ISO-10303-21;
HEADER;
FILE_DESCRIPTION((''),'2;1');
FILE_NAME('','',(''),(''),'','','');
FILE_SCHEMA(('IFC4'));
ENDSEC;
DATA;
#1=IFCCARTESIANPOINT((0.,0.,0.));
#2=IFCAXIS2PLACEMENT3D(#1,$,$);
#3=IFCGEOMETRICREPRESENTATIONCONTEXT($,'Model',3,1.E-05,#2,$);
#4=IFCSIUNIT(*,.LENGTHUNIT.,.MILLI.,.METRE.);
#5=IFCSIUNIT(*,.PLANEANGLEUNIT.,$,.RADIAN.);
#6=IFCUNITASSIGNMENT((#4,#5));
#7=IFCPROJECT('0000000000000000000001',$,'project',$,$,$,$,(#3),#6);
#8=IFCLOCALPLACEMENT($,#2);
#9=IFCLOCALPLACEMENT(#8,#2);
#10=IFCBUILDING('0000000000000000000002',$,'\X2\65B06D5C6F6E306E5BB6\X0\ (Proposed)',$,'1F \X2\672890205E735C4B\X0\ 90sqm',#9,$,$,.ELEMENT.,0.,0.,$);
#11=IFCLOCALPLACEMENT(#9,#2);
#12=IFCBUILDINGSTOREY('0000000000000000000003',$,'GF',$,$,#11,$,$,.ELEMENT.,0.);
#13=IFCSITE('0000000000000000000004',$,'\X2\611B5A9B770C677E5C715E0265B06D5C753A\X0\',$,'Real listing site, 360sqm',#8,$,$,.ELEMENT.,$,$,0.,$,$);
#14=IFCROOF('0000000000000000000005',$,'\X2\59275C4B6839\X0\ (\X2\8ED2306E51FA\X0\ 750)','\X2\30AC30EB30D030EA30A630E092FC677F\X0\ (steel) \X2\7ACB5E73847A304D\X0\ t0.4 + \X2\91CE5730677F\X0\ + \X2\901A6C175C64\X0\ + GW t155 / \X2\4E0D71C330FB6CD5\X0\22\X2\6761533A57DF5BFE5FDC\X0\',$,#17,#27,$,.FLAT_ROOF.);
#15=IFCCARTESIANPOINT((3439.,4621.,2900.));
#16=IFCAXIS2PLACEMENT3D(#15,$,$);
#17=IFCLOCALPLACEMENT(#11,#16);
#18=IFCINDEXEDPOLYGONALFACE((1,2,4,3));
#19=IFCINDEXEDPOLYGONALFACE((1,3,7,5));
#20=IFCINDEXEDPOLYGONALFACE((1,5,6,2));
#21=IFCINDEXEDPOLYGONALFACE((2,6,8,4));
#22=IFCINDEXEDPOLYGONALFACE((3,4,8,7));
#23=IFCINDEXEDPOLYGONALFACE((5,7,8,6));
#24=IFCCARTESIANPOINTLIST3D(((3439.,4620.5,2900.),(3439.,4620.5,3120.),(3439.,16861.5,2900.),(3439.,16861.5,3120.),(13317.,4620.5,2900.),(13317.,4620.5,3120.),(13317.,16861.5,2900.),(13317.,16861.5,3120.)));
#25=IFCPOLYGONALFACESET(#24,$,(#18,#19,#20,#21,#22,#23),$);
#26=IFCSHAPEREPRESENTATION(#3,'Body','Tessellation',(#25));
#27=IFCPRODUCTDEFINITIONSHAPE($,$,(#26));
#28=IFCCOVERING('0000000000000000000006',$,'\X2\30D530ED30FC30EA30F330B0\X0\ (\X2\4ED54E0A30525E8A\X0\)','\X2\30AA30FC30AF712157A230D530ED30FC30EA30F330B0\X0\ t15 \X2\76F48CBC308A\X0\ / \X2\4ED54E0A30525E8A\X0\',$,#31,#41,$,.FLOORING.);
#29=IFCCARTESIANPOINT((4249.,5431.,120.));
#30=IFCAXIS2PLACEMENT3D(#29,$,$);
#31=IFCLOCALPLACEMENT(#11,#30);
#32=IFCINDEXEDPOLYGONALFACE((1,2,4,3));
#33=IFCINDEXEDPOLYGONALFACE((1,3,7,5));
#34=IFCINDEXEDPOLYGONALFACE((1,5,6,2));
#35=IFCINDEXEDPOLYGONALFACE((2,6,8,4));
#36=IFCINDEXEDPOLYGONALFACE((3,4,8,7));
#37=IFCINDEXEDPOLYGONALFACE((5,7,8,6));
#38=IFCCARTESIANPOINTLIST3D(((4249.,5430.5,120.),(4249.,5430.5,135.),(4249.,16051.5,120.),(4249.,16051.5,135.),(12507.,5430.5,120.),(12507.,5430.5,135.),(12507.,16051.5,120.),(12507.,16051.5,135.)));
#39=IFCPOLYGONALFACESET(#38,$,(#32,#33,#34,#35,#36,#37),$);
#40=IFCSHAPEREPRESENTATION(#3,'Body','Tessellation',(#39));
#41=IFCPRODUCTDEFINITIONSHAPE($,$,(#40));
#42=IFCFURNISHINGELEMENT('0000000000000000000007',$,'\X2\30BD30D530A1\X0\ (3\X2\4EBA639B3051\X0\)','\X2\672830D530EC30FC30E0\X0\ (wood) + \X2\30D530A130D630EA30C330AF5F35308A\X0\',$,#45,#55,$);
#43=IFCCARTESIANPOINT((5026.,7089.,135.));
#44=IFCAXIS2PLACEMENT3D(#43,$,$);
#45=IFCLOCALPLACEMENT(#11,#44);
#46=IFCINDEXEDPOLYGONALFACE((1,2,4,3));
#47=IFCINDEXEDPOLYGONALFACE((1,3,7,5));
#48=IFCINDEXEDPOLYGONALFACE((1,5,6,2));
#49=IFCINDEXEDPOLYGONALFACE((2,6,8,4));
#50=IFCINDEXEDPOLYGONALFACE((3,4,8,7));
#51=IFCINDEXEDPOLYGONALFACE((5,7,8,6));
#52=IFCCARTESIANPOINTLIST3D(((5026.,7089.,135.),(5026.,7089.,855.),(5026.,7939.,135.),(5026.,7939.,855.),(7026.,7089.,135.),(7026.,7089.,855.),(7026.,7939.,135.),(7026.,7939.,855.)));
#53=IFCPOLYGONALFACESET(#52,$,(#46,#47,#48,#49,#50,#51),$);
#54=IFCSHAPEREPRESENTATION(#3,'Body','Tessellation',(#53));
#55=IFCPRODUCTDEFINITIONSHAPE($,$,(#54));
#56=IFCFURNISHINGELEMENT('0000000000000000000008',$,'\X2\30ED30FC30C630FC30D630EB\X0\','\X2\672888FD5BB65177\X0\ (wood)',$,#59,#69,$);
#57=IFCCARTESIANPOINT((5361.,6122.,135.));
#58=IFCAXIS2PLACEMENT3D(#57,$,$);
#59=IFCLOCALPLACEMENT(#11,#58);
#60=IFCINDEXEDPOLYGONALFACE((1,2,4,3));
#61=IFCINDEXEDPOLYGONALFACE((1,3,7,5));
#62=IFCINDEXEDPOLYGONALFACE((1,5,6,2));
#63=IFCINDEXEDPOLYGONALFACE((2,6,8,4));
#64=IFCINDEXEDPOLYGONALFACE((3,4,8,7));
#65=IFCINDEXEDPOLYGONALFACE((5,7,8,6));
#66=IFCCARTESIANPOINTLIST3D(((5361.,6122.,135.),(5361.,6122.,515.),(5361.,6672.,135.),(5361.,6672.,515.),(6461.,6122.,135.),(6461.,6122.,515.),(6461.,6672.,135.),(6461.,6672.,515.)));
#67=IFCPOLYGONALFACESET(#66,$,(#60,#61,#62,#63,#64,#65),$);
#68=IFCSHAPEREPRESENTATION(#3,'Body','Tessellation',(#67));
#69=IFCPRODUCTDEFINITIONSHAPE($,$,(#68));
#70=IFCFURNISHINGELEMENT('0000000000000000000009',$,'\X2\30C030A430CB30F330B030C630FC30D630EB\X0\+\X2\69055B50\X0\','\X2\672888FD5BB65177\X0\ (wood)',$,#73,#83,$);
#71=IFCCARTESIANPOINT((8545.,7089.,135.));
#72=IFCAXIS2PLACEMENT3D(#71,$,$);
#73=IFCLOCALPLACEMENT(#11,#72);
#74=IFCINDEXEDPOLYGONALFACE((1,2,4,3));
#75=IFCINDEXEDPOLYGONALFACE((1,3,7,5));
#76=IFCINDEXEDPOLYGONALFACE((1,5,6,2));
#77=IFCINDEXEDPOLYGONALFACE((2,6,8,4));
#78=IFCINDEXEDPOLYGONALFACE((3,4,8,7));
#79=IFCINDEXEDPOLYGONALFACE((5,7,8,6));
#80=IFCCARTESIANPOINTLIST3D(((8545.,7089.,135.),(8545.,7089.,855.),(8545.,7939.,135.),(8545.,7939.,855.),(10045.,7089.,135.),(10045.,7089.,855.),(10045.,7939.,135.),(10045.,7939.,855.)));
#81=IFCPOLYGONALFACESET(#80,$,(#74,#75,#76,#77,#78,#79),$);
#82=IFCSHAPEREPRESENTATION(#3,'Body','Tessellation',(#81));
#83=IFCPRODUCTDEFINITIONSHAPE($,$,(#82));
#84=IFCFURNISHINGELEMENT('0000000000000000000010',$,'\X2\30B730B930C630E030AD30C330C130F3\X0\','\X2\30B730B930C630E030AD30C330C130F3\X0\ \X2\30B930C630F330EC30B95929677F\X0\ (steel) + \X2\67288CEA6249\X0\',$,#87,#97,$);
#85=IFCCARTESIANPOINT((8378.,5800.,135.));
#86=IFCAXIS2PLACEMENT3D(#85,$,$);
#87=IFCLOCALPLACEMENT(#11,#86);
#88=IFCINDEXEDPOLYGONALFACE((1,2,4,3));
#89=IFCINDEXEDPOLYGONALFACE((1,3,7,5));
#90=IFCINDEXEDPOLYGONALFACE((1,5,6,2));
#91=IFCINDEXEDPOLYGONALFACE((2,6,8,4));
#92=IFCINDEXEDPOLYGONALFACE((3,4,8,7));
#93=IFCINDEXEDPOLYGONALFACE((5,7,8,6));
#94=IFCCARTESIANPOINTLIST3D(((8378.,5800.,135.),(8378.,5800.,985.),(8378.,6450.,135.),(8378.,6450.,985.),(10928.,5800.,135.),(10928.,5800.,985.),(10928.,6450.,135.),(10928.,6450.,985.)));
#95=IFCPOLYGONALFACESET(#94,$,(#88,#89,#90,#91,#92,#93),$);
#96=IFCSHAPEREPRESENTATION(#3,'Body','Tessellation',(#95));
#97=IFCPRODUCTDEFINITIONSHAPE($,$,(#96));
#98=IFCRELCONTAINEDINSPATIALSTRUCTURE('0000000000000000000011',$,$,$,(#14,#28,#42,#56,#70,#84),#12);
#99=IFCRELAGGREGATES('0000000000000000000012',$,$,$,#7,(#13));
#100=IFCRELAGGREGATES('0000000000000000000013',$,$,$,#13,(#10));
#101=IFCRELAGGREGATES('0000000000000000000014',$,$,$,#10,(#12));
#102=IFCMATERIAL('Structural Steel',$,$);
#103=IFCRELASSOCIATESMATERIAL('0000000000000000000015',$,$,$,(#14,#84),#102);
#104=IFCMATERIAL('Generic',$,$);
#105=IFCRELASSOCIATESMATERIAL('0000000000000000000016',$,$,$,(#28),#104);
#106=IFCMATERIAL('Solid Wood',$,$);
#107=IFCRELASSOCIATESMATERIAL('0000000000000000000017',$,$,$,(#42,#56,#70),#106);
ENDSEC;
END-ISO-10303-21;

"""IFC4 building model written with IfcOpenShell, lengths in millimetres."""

from ifc_helpers import new_model, si_unit, frame, frame_2d, origin, place, context, project, spatial, rectangle, extrude, material, element, save


model = new_model("IFC4")

# Units and contexts
model_context = context("Model", 3, precision=1e-05, world=origin())
ifc_project = project(units=[si_unit("LENGTHUNIT", "METRE", prefix="MILLI"), si_unit("PLANEANGLEUNIT", "RADIAN")], contexts=[model_context])

# Site, building, storey
site_placement = place(None, origin())
site = spatial("IfcSite", under=ifc_project, at=site_placement, Name="愛媛県松山市新浜町", ObjectType="Real listing site, 360sqm", CompositionType="ELEMENT", RefElevation=0.0)
building_placement = place(site_placement, origin())
building = spatial("IfcBuilding", under=site, at=building_placement, Name="新浜潮の家 (Proposed)", ObjectType="1F 木造平屋 90sqm", CompositionType="ELEMENT", ElevationOfRefHeight=0.0, ElevationOfTerrain=0.0)
storey_placement = place(building_placement, origin())
storey = spatial("IfcBuildingStorey", under=building, at=storey_placement, Name="GF", CompositionType="ELEMENT", Elevation=0.0)

# Shared definitions
ifc_material_1 = material(Name="Solid Wood")

# Roof
ifc_material_2 = material(Name="Structural Steel")
roof_placement = place(storey_placement, frame((3439.0, 4621.0, 2900.0)))
element("IfcRoof", 1, at=roof_placement, inside=storey, material=ifc_material_2, Name="大屋根 (軒の出 750)", Description="ガルバリウム鋼板 (steel) 立平葺き t0.4 + 野地板 + 通気層 + GW t155 / 不燃・法22条区域対応", PredefinedType="FLAT_ROOF", context=model_context, shape_type="SweptSolid", body=[
    extrude(rectangle(XDim=9878.0, YDim=12241.0, at=frame_2d((4939.0, 6120.0))), frame((3439.0, 4621.0, 2900.0)), (0.0, 0.0, 1.0), 220.0),
])

# Covering
ifc_material_3 = material(Name="Generic")
covering_placement = place(storey_placement, frame((4249.0, 5431.0, 120.0)))
element("IfcCovering", 2, at=covering_placement, inside=storey, material=ifc_material_3, Name="フローリング (仕上げ床)", Description="オーク無垢フローリング t15 直貼り / 仕上げ床", PredefinedType="FLOORING", context=model_context, shape_type="SweptSolid", body=[
    extrude(rectangle(XDim=8258.0, YDim=10621.0, at=frame_2d((4129.0, 5310.0))), frame((4249.0, 5431.0, 120.0)), (0.0, 0.0, 1.0), 15.0),
])

# Furnishing elements
furnishing_1_placement = place(storey_placement, frame((5026.0, 7089.0, 135.0)))
element("IfcFurnishingElement", 3, at=furnishing_1_placement, inside=storey, material=ifc_material_1, Name="ソファ (3人掛け)", Description="木フレーム (wood) + ファブリック張り", context=model_context, shape_type="SweptSolid", body=[
    extrude(rectangle(XDim=2000.0, YDim=850.0, at=frame_2d((1000.0, 425.0))), frame((5026.0, 7089.0, 135.0)), (0.0, 0.0, 1.0), 720.0),
])
furnishing_2_placement = place(storey_placement, frame((5361.0, 6122.0, 135.0)))
element("IfcFurnishingElement", 4, at=furnishing_2_placement, inside=storey, material=ifc_material_1, Name="ローテーブル", Description="木製家具 (wood)", context=model_context, shape_type="SweptSolid", body=[
    extrude(rectangle(XDim=1100.0, YDim=550.0, at=frame_2d((550.0, 275.0))), frame((5361.0, 6122.0, 135.0)), (0.0, 0.0, 1.0), 380.0),
])
furnishing_3_placement = place(storey_placement, frame((8545.0, 7089.0, 135.0)))
element("IfcFurnishingElement", 5, at=furnishing_3_placement, inside=storey, material=ifc_material_1, Name="ダイニングテーブル+椅子", Description="木製家具 (wood)", context=model_context, shape_type="SweptSolid", body=[
    extrude(rectangle(XDim=1500.0, YDim=850.0, at=frame_2d((750.0, 425.0))), frame((8545.0, 7089.0, 135.0)), (0.0, 0.0, 1.0), 720.0),
])
furnishing_4_placement = place(storey_placement, frame((8378.0, 5800.0, 135.0)))
element("IfcFurnishingElement", 6, at=furnishing_4_placement, inside=storey, material=ifc_material_2, Name="システムキッチン", Description="システムキッチン ステンレス天板 (steel) + 木質扉", context=model_context, shape_type="SweptSolid", body=[
    extrude(rectangle(XDim=2550.0, YDim=650.0, at=frame_2d((1275.0, 325.0))), frame((8378.0, 5800.0, 135.0)), (0.0, 0.0, 1.0), 850.0),
])

save(model, "model.ifc")
